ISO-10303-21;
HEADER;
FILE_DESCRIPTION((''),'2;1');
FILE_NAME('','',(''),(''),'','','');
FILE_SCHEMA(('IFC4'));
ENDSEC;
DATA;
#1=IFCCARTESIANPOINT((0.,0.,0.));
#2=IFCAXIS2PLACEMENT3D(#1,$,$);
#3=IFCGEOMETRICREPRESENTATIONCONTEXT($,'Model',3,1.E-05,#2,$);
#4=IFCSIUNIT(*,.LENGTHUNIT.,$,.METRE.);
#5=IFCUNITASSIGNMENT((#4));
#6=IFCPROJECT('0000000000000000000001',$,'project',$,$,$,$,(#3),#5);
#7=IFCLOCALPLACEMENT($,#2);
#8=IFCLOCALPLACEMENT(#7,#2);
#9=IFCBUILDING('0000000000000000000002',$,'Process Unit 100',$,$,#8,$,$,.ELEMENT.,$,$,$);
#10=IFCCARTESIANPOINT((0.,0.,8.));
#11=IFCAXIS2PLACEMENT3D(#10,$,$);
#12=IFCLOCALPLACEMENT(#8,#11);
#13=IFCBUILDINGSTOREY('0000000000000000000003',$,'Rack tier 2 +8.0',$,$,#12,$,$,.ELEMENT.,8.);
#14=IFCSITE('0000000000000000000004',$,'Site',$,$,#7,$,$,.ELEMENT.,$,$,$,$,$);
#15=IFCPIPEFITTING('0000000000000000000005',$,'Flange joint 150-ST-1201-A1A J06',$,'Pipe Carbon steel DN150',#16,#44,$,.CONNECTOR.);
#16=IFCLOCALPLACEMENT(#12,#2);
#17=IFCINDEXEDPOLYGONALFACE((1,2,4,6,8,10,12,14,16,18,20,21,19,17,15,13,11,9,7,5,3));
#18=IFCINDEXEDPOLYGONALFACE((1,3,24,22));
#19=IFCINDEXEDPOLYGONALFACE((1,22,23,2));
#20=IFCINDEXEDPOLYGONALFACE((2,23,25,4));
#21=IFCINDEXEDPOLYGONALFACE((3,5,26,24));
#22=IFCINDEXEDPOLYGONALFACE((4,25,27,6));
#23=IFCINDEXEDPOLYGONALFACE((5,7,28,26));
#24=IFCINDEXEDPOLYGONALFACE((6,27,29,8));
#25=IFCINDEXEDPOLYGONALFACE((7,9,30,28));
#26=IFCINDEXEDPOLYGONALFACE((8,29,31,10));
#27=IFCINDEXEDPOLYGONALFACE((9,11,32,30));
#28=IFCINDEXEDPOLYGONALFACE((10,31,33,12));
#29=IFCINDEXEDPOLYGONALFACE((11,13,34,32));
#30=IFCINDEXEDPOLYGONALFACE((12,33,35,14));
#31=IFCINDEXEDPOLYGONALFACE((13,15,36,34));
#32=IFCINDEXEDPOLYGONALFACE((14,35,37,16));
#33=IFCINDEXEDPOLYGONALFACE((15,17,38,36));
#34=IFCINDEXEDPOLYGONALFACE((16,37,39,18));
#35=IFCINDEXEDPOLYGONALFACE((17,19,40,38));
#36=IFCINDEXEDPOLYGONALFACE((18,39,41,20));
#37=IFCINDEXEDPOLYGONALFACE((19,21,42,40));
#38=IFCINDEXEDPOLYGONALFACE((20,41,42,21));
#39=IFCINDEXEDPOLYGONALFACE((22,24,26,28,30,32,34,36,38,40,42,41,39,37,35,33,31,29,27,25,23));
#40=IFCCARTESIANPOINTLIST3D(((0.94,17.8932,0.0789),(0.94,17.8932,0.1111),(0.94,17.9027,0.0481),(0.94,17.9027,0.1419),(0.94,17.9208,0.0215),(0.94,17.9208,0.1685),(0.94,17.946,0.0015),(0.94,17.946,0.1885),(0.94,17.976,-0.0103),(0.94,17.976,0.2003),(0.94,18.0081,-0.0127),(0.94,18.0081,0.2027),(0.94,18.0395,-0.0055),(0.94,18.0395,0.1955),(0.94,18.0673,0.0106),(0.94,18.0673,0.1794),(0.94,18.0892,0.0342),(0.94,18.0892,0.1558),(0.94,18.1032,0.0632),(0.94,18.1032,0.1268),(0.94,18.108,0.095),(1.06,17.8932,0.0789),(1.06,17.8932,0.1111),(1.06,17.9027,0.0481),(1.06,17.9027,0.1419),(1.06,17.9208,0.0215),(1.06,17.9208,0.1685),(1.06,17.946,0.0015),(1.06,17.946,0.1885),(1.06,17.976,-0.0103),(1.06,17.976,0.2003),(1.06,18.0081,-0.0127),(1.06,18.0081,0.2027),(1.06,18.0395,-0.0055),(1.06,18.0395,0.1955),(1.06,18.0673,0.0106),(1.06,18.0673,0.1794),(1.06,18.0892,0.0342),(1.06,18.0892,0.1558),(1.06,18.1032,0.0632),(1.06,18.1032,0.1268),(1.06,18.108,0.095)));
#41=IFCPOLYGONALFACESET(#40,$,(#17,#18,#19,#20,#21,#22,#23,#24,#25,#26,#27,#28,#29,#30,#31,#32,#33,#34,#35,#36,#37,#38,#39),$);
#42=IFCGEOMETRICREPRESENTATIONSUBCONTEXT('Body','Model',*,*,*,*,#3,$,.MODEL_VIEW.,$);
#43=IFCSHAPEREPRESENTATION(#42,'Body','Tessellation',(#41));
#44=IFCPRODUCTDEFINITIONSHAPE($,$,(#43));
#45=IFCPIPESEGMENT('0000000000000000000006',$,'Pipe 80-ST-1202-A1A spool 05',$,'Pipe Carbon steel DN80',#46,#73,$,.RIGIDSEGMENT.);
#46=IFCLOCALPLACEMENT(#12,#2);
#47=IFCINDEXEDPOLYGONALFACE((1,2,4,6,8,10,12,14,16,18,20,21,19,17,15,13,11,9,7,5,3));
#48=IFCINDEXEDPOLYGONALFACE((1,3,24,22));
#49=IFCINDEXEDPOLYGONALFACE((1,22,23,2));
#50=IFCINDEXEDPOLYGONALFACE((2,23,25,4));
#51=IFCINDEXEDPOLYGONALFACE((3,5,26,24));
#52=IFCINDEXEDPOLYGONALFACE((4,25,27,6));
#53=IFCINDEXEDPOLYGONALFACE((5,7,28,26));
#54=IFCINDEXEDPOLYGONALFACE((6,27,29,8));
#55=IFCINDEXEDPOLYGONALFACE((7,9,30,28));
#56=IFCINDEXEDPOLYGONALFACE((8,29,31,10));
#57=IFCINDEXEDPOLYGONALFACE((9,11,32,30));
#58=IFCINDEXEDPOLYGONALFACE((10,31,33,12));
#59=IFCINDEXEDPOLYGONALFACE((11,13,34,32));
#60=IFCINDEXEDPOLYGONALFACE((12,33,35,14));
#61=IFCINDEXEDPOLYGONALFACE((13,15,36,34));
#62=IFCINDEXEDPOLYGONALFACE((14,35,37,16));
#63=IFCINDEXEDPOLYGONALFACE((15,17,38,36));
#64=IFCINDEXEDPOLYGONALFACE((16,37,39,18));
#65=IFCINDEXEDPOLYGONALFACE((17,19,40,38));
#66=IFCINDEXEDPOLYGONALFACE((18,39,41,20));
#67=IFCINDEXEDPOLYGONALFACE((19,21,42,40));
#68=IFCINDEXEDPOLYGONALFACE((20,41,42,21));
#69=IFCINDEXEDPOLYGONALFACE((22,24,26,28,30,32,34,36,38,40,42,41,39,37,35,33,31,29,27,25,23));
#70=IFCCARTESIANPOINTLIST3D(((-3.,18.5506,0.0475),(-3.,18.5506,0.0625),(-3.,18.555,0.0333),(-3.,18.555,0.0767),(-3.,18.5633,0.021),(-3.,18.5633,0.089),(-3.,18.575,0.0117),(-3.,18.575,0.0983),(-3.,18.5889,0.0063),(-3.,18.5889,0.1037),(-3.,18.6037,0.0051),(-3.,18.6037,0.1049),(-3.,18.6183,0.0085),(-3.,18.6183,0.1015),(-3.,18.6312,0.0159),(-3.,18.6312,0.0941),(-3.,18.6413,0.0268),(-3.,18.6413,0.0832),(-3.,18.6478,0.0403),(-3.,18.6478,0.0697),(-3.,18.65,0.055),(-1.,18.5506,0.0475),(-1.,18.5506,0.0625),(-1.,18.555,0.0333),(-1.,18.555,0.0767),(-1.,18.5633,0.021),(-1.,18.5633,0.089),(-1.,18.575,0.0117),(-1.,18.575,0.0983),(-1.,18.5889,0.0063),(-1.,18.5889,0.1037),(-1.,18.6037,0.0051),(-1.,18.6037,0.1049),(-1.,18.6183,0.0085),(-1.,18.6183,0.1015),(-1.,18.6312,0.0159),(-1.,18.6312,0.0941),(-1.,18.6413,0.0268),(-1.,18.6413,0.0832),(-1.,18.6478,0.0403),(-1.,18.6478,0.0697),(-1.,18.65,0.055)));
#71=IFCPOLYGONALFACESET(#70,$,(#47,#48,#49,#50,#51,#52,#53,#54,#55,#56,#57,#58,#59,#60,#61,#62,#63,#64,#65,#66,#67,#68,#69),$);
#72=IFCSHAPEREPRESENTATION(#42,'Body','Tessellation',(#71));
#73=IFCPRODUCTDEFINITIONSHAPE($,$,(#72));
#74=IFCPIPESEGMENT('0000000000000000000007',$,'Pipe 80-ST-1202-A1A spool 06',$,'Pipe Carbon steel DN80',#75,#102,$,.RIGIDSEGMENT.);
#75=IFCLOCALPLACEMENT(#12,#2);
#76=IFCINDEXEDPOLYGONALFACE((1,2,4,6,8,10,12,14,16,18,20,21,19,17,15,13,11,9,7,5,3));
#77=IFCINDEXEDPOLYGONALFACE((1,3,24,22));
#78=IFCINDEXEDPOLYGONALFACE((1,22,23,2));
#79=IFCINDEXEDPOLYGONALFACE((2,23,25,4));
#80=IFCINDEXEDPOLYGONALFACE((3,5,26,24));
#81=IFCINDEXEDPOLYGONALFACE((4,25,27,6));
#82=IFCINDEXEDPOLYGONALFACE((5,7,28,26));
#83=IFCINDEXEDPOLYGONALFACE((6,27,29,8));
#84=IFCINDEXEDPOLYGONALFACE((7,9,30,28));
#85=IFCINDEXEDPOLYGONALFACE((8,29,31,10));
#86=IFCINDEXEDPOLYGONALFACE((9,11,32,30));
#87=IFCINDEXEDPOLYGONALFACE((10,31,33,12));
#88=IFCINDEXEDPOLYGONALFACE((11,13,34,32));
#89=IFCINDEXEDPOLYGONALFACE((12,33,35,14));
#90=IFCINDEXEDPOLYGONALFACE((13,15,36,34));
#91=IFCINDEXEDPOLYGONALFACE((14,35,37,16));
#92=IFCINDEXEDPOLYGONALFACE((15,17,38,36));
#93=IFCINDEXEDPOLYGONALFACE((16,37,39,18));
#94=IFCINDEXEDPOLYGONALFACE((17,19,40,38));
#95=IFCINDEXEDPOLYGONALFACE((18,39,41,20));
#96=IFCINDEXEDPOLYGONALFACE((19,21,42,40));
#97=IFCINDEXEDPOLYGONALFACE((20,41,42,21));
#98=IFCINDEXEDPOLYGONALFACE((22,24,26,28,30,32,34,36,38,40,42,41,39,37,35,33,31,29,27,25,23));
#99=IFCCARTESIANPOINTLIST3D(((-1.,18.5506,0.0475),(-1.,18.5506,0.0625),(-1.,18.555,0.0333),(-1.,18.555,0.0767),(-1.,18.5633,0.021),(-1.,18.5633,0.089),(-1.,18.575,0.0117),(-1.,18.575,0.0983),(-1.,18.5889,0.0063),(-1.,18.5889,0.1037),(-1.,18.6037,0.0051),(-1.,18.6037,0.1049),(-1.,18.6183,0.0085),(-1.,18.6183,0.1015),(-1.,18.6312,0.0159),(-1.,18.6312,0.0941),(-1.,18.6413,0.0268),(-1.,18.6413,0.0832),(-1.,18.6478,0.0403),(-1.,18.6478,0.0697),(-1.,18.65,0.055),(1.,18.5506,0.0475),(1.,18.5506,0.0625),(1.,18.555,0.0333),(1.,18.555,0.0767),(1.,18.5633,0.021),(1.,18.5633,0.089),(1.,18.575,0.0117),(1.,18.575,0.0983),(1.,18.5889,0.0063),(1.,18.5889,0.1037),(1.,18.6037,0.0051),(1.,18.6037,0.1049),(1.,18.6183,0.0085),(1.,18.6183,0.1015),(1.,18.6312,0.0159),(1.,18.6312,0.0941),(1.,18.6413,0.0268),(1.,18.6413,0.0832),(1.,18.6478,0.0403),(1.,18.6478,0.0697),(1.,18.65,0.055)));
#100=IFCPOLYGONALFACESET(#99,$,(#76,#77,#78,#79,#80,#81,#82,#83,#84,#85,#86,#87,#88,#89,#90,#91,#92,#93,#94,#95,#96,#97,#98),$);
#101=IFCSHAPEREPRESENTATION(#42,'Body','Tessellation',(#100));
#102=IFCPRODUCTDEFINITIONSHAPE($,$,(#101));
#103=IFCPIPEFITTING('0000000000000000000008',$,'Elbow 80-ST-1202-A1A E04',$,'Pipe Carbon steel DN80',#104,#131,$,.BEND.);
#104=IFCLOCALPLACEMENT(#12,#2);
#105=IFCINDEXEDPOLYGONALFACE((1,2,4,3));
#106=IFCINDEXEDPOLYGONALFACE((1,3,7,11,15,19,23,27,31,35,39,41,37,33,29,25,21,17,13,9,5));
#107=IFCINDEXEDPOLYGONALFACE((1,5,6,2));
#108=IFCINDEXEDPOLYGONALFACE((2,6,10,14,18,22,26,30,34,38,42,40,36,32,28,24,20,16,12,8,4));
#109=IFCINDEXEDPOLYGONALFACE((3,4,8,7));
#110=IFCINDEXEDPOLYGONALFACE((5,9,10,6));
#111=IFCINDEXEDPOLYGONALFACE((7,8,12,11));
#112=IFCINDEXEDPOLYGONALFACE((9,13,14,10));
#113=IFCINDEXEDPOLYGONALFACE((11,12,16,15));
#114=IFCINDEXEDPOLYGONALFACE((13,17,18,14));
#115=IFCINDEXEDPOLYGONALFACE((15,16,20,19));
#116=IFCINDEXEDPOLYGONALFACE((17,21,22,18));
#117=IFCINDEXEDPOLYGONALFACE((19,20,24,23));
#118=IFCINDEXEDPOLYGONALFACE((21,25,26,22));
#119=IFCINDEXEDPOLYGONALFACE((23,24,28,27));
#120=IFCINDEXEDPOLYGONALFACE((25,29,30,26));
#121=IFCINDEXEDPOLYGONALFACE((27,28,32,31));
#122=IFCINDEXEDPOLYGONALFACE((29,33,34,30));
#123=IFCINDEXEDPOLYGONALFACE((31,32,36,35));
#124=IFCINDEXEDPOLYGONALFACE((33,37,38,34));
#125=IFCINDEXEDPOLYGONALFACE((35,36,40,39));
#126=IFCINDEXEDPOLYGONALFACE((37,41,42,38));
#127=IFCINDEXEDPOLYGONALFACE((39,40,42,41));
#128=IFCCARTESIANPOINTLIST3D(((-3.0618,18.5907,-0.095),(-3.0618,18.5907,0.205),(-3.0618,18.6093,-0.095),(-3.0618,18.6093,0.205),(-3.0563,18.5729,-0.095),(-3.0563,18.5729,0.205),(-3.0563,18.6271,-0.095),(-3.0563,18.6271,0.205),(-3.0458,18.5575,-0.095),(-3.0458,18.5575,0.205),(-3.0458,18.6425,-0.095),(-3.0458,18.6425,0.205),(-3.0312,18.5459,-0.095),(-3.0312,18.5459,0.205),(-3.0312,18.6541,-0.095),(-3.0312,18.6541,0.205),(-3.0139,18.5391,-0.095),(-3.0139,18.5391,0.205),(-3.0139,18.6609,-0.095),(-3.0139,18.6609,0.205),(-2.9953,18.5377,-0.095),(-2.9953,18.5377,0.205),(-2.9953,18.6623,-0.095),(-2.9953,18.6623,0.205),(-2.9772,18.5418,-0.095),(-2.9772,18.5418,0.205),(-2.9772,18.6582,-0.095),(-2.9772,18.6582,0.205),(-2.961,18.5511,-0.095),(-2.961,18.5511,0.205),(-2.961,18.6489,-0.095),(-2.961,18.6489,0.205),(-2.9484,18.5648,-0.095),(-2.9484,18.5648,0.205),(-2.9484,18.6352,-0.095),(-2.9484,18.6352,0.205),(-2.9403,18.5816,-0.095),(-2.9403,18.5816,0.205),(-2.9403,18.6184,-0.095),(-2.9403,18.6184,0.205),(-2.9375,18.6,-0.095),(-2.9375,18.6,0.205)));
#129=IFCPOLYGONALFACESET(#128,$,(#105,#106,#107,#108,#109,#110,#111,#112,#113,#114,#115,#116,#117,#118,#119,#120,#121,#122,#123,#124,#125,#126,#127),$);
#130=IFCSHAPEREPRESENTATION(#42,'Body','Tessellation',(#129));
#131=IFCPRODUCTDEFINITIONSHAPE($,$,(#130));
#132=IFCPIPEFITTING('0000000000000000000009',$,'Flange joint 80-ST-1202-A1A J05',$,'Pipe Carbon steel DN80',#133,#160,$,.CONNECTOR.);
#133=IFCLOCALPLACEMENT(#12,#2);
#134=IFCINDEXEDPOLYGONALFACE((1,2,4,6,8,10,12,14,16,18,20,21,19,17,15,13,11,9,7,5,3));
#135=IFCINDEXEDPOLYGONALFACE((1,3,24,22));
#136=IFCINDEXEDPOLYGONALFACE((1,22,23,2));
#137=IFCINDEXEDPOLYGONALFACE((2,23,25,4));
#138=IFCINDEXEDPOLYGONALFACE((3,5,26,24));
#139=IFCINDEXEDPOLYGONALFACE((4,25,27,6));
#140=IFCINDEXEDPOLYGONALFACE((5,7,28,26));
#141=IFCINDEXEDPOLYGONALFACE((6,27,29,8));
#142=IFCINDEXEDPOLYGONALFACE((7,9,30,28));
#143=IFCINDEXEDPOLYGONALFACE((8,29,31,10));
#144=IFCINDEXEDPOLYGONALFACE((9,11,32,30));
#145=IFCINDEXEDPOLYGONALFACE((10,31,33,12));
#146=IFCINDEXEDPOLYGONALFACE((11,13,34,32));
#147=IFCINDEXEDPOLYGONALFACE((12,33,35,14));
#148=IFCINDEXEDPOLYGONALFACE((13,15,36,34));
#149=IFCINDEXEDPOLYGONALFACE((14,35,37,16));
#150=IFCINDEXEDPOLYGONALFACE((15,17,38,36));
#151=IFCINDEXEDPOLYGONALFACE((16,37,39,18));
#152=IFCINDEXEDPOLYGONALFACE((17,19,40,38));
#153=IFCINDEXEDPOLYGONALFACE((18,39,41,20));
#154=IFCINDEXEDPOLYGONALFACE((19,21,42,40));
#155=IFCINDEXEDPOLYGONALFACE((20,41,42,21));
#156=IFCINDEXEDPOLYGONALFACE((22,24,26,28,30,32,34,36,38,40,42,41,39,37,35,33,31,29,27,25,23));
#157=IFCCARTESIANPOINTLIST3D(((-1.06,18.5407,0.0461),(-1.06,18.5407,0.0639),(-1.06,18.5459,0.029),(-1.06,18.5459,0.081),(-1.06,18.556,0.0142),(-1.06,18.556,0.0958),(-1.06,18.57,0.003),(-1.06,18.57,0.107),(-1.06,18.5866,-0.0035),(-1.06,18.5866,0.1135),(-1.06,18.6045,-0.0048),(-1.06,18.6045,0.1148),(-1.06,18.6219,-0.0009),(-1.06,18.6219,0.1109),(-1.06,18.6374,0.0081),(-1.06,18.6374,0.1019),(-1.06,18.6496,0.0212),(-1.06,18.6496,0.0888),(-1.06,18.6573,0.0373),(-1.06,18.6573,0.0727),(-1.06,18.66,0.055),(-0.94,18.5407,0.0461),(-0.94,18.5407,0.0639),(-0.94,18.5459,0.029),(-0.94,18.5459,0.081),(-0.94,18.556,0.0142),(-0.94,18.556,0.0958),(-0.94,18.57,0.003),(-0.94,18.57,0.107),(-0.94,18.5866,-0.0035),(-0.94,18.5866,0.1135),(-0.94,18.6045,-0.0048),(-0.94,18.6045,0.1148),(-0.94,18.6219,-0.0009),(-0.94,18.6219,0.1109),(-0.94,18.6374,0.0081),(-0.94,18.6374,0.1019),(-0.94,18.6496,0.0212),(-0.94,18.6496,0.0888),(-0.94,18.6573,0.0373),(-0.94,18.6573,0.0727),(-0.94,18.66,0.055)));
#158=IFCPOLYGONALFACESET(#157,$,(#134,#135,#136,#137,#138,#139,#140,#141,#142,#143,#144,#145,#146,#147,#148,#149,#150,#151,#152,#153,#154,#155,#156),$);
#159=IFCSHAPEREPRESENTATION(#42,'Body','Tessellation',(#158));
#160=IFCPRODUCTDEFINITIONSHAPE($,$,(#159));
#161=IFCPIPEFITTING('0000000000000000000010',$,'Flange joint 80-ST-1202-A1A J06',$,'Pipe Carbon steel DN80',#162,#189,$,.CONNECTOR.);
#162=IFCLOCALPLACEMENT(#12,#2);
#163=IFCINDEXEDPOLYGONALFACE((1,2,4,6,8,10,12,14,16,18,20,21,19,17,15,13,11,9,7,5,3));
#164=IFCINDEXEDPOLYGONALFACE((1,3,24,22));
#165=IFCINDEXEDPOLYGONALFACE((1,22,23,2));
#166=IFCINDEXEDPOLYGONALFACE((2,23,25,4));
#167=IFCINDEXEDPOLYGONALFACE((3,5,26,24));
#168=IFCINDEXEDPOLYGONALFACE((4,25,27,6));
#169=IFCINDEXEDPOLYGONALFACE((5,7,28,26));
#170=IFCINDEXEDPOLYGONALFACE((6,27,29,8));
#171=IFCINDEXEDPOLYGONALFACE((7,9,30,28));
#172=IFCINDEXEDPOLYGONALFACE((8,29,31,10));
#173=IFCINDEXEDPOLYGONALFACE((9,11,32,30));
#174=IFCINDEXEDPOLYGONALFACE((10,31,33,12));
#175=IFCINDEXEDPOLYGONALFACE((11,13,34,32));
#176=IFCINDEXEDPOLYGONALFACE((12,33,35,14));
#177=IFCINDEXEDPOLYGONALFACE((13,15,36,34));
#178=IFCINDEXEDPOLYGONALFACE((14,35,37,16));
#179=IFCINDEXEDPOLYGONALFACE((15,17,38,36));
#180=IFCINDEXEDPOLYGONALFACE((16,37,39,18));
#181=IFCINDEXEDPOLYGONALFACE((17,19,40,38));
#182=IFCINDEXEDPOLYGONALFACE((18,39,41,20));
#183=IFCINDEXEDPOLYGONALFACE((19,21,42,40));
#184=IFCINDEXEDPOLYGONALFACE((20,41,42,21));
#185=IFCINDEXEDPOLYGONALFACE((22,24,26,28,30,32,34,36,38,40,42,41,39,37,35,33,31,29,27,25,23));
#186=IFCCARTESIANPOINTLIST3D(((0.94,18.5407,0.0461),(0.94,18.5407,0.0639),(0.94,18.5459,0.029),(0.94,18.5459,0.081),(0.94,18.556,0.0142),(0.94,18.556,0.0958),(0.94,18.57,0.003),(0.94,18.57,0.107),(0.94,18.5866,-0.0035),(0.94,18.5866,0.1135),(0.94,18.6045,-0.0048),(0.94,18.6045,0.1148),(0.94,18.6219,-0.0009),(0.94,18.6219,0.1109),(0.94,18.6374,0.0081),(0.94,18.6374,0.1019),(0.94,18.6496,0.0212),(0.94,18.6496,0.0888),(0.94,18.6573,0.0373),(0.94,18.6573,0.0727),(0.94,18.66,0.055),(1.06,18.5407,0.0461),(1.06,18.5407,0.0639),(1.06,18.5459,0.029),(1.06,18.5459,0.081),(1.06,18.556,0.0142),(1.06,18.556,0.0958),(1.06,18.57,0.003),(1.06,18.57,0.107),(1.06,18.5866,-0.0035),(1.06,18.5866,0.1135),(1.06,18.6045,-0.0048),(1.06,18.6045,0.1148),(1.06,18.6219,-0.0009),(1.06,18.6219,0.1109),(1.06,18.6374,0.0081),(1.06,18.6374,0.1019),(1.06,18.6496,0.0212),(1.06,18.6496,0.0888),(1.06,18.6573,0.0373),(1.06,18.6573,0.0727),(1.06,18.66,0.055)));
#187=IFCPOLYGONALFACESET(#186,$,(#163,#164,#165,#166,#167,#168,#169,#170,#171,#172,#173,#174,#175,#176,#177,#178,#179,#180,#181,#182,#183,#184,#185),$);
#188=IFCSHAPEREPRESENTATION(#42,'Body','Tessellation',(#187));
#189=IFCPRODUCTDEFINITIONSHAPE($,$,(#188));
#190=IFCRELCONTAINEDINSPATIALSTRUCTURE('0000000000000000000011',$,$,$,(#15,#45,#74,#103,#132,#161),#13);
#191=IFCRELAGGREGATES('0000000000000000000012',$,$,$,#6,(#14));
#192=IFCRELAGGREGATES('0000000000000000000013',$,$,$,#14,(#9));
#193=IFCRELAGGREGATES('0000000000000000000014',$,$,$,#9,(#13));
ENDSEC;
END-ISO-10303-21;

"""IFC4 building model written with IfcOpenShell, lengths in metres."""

from ifc_helpers import new_model, si_unit, frame, origin, place, context, subcontext, project, spatial, circle, extrude, element, save


model = new_model("IFC4")

# Units and contexts
model_context = context("Model", 3, precision=1e-05, world=origin())
body_context = subcontext(model_context, "Body", "Model", "MODEL_VIEW")
ifc_project = project(units=[si_unit("LENGTHUNIT", "METRE")], contexts=[model_context])

# Site, building, storey
site_placement = place(None, origin())
site = spatial("IfcSite", under=ifc_project, at=site_placement, Name="Site", CompositionType="ELEMENT")
building_placement = place(site_placement, origin())
building = spatial("IfcBuilding", under=site, at=building_placement, Name="Process Unit 100", CompositionType="ELEMENT")
storey_placement = place(building_placement, frame((0.0, 0.0, 8.0)))
storey = spatial("IfcBuildingStorey", under=building, at=storey_placement, Name="Rack tier 2 +8.0", CompositionType="ELEMENT", Elevation=8.0)

# Pipe fitting
for number, where, z_axis, x_axis, name in (
    (1, (0.94, 18.0, 0.095), (1.0, 0.0, 0.0), (0.0, 1.0, 0.0), "Flange joint 150-ST-1201-A1A J06"),
):
    element("IfcPipeFitting", number, at=place(storey_placement, frame(where, z_axis=z_axis, x_axis=x_axis)), inside=storey, Name=name, ObjectType="Pipe Carbon steel DN150", PredefinedType="CONNECTOR", context=body_context, shape_type="SweptSolid", body=[
        extrude(circle(Radius=0.108), origin(), (0.0, 0.0, 1.0), 0.12),
    ])

# Pipe segments
for number, where, z_axis, x_axis, name in (
    (2, (-3.0, 18.6, 0.055), (1.0, 0.0, 0.0), (0.0, 1.0, 0.0), "Pipe 80-ST-1202-A1A spool 05"),
    (3, (-1.0, 18.6, 0.055), (1.0, 0.0, 0.0), (0.0, 1.0, 0.0), "Pipe 80-ST-1202-A1A spool 06"),
):
    element("IfcPipeSegment", number, at=place(storey_placement, frame(where, z_axis=z_axis, x_axis=x_axis)), inside=storey, Name=name, ObjectType="Pipe Carbon steel DN80", PredefinedType="RIGIDSEGMENT", context=body_context, shape_type="SweptSolid", body=[
        extrude(circle(Radius=0.05), origin(), (0.0, 0.0, 1.0), 2.0),
    ])

# Pipe fittings
pipe_fitting_1_placement = place(storey_placement, frame((-3.0, 18.6, -0.095), z_axis=(0.0, 0.0, 1.0), x_axis=(1.0, 0.0, 0.0)))
element("IfcPipeFitting", 4, at=pipe_fitting_1_placement, inside=storey, Name="Elbow 80-ST-1202-A1A E04", ObjectType="Pipe Carbon steel DN80", PredefinedType="BEND", context=body_context, shape_type="SweptSolid", body=[
    extrude(circle(Radius=0.0625), origin(), (0.0, 0.0, 1.0), 0.3),
])
for number, where, z_axis, x_axis, name in (
    (5, (-1.06, 18.6, 0.055), (1.0, 0.0, 0.0), (0.0, 1.0, 0.0), "Flange joint 80-ST-1202-A1A J05"),
    (6, (0.94, 18.6, 0.055), (1.0, 0.0, 0.0), (0.0, 1.0, 0.0), "Flange joint 80-ST-1202-A1A J06"),
):
    element("IfcPipeFitting", number, at=place(storey_placement, frame(where, z_axis=z_axis, x_axis=x_axis)), inside=storey, Name=name, ObjectType="Pipe Carbon steel DN80", PredefinedType="CONNECTOR", context=body_context, shape_type="SweptSolid", body=[
        extrude(circle(Radius=0.06), origin(), (0.0, 0.0, 1.0), 0.12),
    ])

save(model, "model.ifc")
